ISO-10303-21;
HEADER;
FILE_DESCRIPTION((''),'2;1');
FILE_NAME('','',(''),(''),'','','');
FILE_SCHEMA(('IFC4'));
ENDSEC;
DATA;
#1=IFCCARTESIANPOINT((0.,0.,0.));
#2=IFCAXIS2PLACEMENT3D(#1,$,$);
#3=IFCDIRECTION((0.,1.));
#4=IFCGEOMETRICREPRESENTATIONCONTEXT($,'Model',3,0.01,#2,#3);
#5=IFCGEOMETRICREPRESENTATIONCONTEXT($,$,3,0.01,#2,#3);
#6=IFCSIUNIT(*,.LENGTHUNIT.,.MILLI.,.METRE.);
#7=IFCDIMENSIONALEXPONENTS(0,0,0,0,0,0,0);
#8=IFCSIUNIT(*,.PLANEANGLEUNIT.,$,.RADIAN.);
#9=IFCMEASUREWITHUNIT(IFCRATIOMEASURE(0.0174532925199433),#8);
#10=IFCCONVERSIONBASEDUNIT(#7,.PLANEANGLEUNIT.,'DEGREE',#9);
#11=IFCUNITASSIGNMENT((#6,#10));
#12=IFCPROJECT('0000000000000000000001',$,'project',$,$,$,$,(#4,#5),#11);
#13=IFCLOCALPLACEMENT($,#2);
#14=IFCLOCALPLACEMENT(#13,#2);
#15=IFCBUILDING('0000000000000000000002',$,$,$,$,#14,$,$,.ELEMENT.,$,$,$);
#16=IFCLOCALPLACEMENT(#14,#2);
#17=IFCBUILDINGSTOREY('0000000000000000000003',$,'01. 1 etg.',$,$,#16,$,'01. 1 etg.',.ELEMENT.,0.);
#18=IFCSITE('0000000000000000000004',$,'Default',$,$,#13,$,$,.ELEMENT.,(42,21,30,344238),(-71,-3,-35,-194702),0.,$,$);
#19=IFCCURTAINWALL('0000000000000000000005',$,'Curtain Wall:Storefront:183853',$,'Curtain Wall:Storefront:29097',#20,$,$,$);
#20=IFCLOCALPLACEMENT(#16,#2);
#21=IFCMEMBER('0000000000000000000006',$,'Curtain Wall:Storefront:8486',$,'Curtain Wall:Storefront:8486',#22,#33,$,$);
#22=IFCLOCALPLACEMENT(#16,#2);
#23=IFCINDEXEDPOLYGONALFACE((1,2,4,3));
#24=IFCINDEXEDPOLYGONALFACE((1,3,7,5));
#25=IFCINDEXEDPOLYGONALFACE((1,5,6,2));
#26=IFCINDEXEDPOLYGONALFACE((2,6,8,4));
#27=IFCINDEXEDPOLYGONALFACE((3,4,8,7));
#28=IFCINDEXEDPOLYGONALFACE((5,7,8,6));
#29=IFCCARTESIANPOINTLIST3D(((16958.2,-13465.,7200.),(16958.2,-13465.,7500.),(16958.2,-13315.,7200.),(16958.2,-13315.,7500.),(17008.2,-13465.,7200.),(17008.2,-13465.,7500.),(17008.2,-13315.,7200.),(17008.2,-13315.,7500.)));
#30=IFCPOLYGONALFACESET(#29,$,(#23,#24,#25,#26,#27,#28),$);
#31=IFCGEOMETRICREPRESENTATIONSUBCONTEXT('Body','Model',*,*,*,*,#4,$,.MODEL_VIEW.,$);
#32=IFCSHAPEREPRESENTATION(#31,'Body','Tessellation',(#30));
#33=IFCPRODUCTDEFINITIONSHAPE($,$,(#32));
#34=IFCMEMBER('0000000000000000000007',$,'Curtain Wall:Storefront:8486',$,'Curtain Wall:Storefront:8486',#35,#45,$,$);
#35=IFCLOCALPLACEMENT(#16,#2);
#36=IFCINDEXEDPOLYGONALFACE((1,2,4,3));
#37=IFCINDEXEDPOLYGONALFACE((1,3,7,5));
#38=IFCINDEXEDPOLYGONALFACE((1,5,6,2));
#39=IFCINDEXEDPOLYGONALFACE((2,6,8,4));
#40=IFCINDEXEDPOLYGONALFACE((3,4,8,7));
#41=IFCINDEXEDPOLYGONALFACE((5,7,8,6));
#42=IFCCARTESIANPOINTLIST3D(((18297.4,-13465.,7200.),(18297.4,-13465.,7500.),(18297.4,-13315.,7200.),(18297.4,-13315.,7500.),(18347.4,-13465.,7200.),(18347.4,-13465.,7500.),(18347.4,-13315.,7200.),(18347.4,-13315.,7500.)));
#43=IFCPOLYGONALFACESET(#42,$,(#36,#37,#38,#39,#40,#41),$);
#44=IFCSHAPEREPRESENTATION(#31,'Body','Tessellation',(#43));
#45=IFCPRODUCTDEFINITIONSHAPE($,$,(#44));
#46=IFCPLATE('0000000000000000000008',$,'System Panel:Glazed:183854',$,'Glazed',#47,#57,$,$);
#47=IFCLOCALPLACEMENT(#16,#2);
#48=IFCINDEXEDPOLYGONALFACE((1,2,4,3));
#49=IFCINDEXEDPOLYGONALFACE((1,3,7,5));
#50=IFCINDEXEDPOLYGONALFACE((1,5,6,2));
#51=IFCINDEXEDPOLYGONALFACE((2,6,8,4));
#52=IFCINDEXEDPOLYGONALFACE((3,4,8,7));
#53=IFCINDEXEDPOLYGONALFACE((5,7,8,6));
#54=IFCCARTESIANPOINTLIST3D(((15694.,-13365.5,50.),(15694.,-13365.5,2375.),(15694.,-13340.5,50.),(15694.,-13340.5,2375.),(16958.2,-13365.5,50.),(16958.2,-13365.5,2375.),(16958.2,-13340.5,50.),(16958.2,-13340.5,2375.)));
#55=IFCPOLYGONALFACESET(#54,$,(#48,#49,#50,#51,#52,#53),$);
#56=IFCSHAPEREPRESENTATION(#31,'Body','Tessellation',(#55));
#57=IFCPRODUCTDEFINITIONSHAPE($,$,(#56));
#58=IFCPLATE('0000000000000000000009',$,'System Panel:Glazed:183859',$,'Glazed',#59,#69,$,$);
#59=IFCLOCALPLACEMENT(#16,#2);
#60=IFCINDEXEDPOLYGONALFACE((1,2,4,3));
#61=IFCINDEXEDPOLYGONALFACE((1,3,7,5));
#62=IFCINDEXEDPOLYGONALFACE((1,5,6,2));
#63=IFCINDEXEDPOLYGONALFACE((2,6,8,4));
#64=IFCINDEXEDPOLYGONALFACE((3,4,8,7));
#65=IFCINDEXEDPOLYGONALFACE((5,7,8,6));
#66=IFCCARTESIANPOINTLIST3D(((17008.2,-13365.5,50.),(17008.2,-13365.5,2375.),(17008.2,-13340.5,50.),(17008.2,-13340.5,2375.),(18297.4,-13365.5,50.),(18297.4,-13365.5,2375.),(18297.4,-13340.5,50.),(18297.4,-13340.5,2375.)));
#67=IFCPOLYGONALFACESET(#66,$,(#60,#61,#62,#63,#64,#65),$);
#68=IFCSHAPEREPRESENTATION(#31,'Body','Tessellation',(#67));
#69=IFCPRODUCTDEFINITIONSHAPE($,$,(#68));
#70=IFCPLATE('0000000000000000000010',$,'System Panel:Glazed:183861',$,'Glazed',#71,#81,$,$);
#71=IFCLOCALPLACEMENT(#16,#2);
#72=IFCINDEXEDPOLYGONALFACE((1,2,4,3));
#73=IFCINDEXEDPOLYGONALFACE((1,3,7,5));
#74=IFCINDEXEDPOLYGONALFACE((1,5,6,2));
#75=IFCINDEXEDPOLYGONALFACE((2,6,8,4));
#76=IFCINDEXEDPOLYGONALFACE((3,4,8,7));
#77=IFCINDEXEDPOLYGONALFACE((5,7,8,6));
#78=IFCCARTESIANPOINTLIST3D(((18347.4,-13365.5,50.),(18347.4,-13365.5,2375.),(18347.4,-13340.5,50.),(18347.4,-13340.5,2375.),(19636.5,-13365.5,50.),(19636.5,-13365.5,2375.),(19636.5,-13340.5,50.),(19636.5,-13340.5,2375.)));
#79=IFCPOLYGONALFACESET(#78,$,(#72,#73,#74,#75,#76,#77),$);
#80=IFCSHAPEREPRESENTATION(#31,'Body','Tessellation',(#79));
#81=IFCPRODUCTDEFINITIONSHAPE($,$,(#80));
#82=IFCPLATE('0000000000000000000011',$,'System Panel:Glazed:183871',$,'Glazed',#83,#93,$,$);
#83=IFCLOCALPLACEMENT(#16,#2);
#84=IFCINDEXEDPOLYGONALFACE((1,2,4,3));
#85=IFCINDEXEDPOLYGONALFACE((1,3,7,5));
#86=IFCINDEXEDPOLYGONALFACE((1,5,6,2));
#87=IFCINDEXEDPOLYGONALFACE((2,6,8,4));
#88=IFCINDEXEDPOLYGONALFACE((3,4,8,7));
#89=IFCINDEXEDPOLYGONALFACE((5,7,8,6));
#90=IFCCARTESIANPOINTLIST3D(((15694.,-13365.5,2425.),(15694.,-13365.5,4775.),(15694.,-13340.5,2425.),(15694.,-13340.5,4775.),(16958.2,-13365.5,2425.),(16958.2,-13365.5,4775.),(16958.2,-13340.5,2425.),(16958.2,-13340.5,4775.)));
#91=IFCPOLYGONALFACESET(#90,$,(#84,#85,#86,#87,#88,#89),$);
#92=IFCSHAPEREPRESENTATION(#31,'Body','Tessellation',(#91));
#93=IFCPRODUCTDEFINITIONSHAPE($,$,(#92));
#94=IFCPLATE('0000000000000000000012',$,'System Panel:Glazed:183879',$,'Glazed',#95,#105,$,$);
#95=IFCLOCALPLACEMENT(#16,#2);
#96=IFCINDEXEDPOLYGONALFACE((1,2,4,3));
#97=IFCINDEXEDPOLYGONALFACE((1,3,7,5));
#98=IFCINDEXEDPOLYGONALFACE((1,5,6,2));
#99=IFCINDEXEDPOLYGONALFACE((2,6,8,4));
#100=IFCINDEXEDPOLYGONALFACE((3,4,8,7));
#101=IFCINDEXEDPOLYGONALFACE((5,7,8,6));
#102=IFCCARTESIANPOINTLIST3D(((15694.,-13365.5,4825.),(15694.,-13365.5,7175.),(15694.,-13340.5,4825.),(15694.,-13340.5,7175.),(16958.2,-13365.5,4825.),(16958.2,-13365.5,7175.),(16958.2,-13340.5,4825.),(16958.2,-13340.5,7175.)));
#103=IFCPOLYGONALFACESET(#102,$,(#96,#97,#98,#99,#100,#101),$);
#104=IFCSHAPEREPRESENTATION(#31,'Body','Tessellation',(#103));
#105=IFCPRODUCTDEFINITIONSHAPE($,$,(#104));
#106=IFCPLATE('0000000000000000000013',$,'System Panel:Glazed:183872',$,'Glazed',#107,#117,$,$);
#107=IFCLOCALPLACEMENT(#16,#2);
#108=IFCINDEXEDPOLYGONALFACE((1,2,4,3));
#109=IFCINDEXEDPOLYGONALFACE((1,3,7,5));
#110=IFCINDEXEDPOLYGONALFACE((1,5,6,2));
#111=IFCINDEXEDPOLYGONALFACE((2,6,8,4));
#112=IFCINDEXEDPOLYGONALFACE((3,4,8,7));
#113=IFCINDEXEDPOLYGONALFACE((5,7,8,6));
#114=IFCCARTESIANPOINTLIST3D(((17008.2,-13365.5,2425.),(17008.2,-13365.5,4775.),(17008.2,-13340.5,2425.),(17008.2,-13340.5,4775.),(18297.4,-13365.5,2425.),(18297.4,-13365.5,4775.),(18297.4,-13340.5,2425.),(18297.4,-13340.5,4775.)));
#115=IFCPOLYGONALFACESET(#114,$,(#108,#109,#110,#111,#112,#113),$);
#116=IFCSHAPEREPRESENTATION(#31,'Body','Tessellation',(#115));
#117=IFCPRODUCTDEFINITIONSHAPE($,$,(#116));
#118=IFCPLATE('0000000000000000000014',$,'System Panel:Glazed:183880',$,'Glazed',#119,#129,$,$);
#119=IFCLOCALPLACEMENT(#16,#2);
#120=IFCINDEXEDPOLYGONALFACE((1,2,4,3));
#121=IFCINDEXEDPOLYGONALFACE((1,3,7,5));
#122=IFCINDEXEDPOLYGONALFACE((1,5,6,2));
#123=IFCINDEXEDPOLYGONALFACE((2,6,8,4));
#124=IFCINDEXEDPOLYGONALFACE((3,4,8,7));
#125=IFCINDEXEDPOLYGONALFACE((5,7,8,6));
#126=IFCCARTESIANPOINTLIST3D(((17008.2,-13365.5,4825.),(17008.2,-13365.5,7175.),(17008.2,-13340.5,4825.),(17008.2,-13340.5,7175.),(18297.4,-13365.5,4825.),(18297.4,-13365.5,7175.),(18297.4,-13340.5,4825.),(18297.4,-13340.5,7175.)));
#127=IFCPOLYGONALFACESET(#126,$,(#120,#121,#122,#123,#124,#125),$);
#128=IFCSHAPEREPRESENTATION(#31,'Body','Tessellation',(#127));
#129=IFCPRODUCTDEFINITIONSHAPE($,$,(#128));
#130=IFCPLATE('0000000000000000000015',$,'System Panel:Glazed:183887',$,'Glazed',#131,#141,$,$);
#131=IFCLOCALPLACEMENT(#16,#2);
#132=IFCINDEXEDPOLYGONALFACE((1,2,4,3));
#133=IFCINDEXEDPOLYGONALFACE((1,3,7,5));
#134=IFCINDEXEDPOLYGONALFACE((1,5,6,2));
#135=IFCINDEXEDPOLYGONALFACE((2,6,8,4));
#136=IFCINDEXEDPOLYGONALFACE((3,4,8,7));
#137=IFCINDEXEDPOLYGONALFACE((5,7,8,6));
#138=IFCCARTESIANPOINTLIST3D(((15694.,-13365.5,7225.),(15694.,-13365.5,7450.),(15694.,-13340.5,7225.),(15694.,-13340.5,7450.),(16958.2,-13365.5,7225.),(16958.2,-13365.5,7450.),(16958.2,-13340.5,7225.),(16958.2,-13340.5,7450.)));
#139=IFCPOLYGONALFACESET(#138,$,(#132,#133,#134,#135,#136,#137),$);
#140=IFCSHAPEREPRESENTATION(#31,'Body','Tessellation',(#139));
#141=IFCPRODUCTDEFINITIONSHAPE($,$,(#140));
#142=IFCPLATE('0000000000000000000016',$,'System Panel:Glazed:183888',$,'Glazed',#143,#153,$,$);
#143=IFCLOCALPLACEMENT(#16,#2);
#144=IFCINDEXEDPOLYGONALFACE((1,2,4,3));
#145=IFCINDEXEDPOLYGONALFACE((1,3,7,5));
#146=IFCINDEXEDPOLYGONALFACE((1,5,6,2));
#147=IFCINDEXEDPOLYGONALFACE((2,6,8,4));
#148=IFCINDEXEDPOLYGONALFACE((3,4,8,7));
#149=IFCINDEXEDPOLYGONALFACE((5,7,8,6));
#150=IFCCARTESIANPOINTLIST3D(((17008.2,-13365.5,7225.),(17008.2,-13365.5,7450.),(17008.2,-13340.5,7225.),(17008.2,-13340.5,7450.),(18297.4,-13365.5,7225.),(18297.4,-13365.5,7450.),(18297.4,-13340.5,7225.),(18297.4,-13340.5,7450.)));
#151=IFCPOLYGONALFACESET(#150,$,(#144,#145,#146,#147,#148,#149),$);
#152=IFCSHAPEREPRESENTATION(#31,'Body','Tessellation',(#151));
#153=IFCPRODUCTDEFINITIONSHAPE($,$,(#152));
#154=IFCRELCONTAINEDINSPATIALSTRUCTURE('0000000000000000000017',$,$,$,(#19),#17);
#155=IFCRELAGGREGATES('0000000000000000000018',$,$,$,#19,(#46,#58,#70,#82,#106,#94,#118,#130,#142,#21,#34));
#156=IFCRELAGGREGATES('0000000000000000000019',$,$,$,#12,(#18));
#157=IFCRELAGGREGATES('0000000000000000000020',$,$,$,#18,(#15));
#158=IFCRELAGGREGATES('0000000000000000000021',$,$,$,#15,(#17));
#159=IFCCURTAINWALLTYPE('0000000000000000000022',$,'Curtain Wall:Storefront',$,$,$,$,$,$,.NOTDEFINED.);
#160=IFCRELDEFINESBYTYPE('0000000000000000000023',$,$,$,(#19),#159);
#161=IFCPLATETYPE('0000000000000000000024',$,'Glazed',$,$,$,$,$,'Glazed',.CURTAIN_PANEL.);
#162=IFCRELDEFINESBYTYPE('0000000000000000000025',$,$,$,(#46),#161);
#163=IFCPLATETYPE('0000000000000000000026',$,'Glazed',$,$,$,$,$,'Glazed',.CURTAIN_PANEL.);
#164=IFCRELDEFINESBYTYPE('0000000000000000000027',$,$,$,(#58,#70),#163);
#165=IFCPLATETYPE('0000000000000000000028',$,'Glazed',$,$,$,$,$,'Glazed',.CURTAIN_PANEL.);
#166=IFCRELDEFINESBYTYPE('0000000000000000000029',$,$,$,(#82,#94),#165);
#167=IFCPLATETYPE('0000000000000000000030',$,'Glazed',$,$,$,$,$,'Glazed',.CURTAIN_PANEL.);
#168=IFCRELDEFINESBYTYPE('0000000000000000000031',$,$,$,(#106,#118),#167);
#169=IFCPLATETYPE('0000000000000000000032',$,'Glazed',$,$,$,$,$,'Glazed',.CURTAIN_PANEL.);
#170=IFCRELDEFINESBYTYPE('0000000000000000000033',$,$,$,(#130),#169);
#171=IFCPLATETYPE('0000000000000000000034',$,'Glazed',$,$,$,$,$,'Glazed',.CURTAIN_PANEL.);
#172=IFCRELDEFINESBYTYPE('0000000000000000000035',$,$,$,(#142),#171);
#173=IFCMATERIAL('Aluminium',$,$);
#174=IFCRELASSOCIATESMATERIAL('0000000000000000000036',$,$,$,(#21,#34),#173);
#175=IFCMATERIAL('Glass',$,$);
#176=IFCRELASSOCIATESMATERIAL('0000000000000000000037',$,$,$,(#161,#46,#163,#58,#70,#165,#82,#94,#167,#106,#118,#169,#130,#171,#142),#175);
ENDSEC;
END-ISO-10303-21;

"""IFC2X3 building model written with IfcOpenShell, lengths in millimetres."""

from ifc_helpers import new_model, entity, si_unit, converted_unit, direction, frame, frame_2d, origin, origin_2d_with_axis, place, context, subcontext, project, spatial, rectangle, extrude, source, transform, mapped, material, type_object, type_shapes, element, aggregate, save


model = new_model("IFC2X3")

# Units and contexts
model_context = context("Model", 3, precision=0.01, world=origin(), true_north=direction((0.0, 1.0)))
context_of_model = context(None, 3, precision=0.01, world=origin(), true_north=direction((0.0, 1.0)))
body_context = subcontext(model_context, "Body", "Model", "MODEL_VIEW")
ifc_project = project(units=[si_unit("LENGTHUNIT", "METRE", prefix="MILLI"), converted_unit("PLANEANGLEUNIT", "DEGREE", entity("IfcRatioMeasure", 0.0174532925199433), si_unit("PLANEANGLEUNIT", "RADIAN"), dimensions=[0, 0, 0, 0, 0, 0, 0])], contexts=[model_context, context_of_model])

# Site, building, storey
site_placement = place(None, origin())
site = spatial("IfcSite", under=ifc_project, at=site_placement, Name="Default", CompositionType="ELEMENT", RefLatitude=(42, 21, 30, 344238), RefLongitude=(-71, -3, -35, -194702), RefElevation=0.0)
building_placement = place(site_placement, origin())
building = spatial("IfcBuilding", under=site, at=building_placement, CompositionType="ELEMENT")
storey_placement = place(building_placement, origin())
storey = spatial("IfcBuildingStorey", under=building, at=storey_placement, Name="01. 1 etg.", LongName="01. 1 etg.", CompositionType="ELEMENT", Elevation=0.0)

# Curtain wall, members, plates
curtain_wall_type = type_object("IfcCurtainWallType", Name="Curtain Wall:Storefront", PredefinedType="NOTDEFINED")
curtain_wall_placement = place(storey_placement, origin())
curtain_wall = element("IfcCurtainWall", 1, at=curtain_wall_placement, inside=storey, type_object=curtain_wall_type, Name="Curtain Wall:Storefront:183853", ObjectType="Curtain Wall:Storefront:29097")
ifc_material_1 = material(Name="Aluminium")
member_1_placement = place(curtain_wall_placement, frame((16958.2, -13465.0, 7200.0)))
member_1 = element("IfcMember", 2, at=member_1_placement, material=ifc_material_1, Name="Curtain Wall:Storefront:8486", ObjectType="Curtain Wall:Storefront:8486", context=body_context, shape_type="SweptSolid", body=[
    extrude(rectangle(XDim=150.0, YDim=50.0, at=frame_2d((0.0, 0.0), x_axis=(1.0, 0.0))), frame((25.0, 75.0, 0.0), z_axis=(0.0, 0.0, 1.0), x_axis=(0.0, 1.0, 0.0)), (0.0, 0.0, 1.0), 300.0),
])
member_2_placement = place(curtain_wall_placement, frame((18297.4, -13465.0, 7200.0)))
member_2 = element("IfcMember", 3, at=member_2_placement, material=ifc_material_1, Name="Curtain Wall:Storefront:8486", ObjectType="Curtain Wall:Storefront:8486", context=body_context, shape_type="SweptSolid", body=[
    extrude(rectangle(XDim=150.0, YDim=50.0, at=frame_2d((0.0, 0.0), x_axis=(1.0, 0.0))), frame((25.0, 75.0, 0.0), z_axis=(0.0, 0.0, 1.0), x_axis=(0.0, 1.0, 0.0)), (0.0, 0.0, 1.0), 300.0),
])
ifc_material_2 = material(Name="Glass")
plate_type_1 = type_object("IfcPlateType", Name="Glazed", ElementType="Glazed", PredefinedType="CURTAIN_PANEL", material=ifc_material_2)
shared_shape_1 = source(origin(), body_context, "Body", "SweptSolid", [
    extrude(rectangle(XDim=25.0, YDim=1264.2, at=origin_2d_with_axis()), frame((632.1, 12.5, 0.0), z_axis=(0.0, 0.0, 1.0), x_axis=(0.0, 1.0, 0.0)), (0.0, 0.0, 1.0), 2325.0),
])
type_shapes(plate_type_1, [shared_shape_1])
plate_1_placement = place(curtain_wall_placement, frame((15694.0, -13365.5, 50.0)))
plate_1 = element("IfcPlate", 4, at=plate_1_placement, type_object=plate_type_1, material=ifc_material_2, Name="System Panel:Glazed:183854", ObjectType="Glazed", context=body_context, shape_type="MappedRepresentation", body=[
    mapped(shared_shape_1, transform((0.0, 0.0, 0.0), scale=1.0)),
])
plate_type_2 = type_object("IfcPlateType", Name="Glazed", ElementType="Glazed", PredefinedType="CURTAIN_PANEL", material=ifc_material_2)
shared_shape_2 = source(origin(), body_context, "Body", "SweptSolid", [
    extrude(rectangle(XDim=25.0, YDim=1289.2, at=origin_2d_with_axis()), frame((644.6, 12.5, 0.0), z_axis=(0.0, 0.0, 1.0), x_axis=(0.0, 1.0, 0.0)), (0.0, 0.0, 1.0), 2325.0),
])
type_shapes(plate_type_2, [shared_shape_2])
plate_2_placement = place(curtain_wall_placement, frame((17008.2, -13365.5, 50.0)))
plate_2 = element("IfcPlate", 5, at=plate_2_placement, type_object=plate_type_2, material=ifc_material_2, Name="System Panel:Glazed:183859", ObjectType="Glazed", context=body_context, shape_type="MappedRepresentation", body=[
    mapped(shared_shape_2, transform((0.0, 0.0, 0.0), scale=1.0)),
])
plate_3_placement = place(curtain_wall_placement, frame((18347.4, -13365.5, 50.0)))
plate_3 = element("IfcPlate", 6, at=plate_3_placement, type_object=plate_type_2, material=ifc_material_2, Name="System Panel:Glazed:183861", ObjectType="Glazed", context=body_context, shape_type="MappedRepresentation", body=[
    mapped(shared_shape_2, transform((0.0, 0.0, 0.0), scale=1.0)),
])
plate_type_3 = type_object("IfcPlateType", Name="Glazed", ElementType="Glazed", PredefinedType="CURTAIN_PANEL", material=ifc_material_2)
shared_shape_3 = source(origin(), body_context, "Body", "SweptSolid", [
    extrude(rectangle(XDim=25.0, YDim=1264.2, at=origin_2d_with_axis()), frame((632.1, 12.5, 0.0), z_axis=(0.0, 0.0, 1.0), x_axis=(0.0, 1.0, 0.0)), (0.0, 0.0, 1.0), 2350.0),
])
type_shapes(plate_type_3, [shared_shape_3])
plate_4_placement = place(curtain_wall_placement, frame((15694.0, -13365.5, 2425.0)))
plate_4 = element("IfcPlate", 7, at=plate_4_placement, type_object=plate_type_3, material=ifc_material_2, Name="System Panel:Glazed:183871", ObjectType="Glazed", context=body_context, shape_type="MappedRepresentation", body=[
    mapped(shared_shape_3, transform((0.0, 0.0, 0.0), scale=1.0)),
])
plate_5_placement = place(curtain_wall_placement, frame((15694.0, -13365.5, 4825.0)))
plate_5 = element("IfcPlate", 8, at=plate_5_placement, type_object=plate_type_3, material=ifc_material_2, Name="System Panel:Glazed:183879", ObjectType="Glazed", context=body_context, shape_type="MappedRepresentation", body=[
    mapped(shared_shape_3, transform((0.0, 0.0, 0.0), scale=1.0)),
])
plate_type_4 = type_object("IfcPlateType", Name="Glazed", ElementType="Glazed", PredefinedType="CURTAIN_PANEL", material=ifc_material_2)
shared_shape_4 = source(origin(), body_context, "Body", "SweptSolid", [
    extrude(rectangle(XDim=25.0, YDim=1289.2, at=origin_2d_with_axis()), frame((644.6, 12.5, 0.0), z_axis=(0.0, 0.0, 1.0), x_axis=(0.0, 1.0, 0.0)), (0.0, 0.0, 1.0), 2350.0),
])
type_shapes(plate_type_4, [shared_shape_4])
plate_6_placement = place(curtain_wall_placement, frame((17008.2, -13365.5, 2425.0)))
plate_6 = element("IfcPlate", 9, at=plate_6_placement, type_object=plate_type_4, material=ifc_material_2, Name="System Panel:Glazed:183872", ObjectType="Glazed", context=body_context, shape_type="MappedRepresentation", body=[
    mapped(shared_shape_4, transform((0.0, 0.0, 0.0), scale=1.0)),
])
plate_7_placement = place(curtain_wall_placement, frame((17008.2, -13365.5, 4825.0)))
plate_7 = element("IfcPlate", 10, at=plate_7_placement, type_object=plate_type_4, material=ifc_material_2, Name="System Panel:Glazed:183880", ObjectType="Glazed", context=body_context, shape_type="MappedRepresentation", body=[
    mapped(shared_shape_4, transform((0.0, 0.0, 0.0), scale=1.0)),
])
plate_type_5 = type_object("IfcPlateType", Name="Glazed", ElementType="Glazed", PredefinedType="CURTAIN_PANEL", material=ifc_material_2)
shared_shape_5 = source(origin(), body_context, "Body", "SweptSolid", [
    extrude(rectangle(XDim=25.0, YDim=1264.2, at=origin_2d_with_axis()), frame((632.1, 12.5, 0.0), z_axis=(0.0, 0.0, 1.0), x_axis=(0.0, 1.0, 0.0)), (0.0, 0.0, 1.0), 225.0),
])
type_shapes(plate_type_5, [shared_shape_5])
plate_8_placement = place(curtain_wall_placement, frame((15694.0, -13365.5, 7225.0)))
plate_8 = element("IfcPlate", 11, at=plate_8_placement, type_object=plate_type_5, material=ifc_material_2, Name="System Panel:Glazed:183887", ObjectType="Glazed", context=body_context, shape_type="MappedRepresentation", body=[
    mapped(shared_shape_5, transform((0.0, 0.0, 0.0), scale=1.0)),
])
plate_type_6 = type_object("IfcPlateType", Name="Glazed", ElementType="Glazed", PredefinedType="CURTAIN_PANEL", material=ifc_material_2)
shared_shape_6 = source(origin(), body_context, "Body", "SweptSolid", [
    extrude(rectangle(XDim=25.0, YDim=1289.2, at=origin_2d_with_axis()), frame((644.6, 12.5, 0.0), z_axis=(0.0, 0.0, 1.0), x_axis=(0.0, 1.0, 0.0)), (0.0, 0.0, 1.0), 225.0),
])
type_shapes(plate_type_6, [shared_shape_6])
plate_9_placement = place(curtain_wall_placement, frame((17008.2, -13365.5, 7225.0)))
plate_9 = element("IfcPlate", 12, at=plate_9_placement, type_object=plate_type_6, material=ifc_material_2, Name="System Panel:Glazed:183888", ObjectType="Glazed", context=body_context, shape_type="MappedRepresentation", body=[
    mapped(shared_shape_6, transform((0.0, 0.0, 0.0), scale=1.0)),
])
aggregate(curtain_wall, [plate_1, plate_2, plate_3, plate_4, plate_6, plate_5, plate_7, plate_8, plate_9, member_1, member_2])

save(model, "model.ifc")
